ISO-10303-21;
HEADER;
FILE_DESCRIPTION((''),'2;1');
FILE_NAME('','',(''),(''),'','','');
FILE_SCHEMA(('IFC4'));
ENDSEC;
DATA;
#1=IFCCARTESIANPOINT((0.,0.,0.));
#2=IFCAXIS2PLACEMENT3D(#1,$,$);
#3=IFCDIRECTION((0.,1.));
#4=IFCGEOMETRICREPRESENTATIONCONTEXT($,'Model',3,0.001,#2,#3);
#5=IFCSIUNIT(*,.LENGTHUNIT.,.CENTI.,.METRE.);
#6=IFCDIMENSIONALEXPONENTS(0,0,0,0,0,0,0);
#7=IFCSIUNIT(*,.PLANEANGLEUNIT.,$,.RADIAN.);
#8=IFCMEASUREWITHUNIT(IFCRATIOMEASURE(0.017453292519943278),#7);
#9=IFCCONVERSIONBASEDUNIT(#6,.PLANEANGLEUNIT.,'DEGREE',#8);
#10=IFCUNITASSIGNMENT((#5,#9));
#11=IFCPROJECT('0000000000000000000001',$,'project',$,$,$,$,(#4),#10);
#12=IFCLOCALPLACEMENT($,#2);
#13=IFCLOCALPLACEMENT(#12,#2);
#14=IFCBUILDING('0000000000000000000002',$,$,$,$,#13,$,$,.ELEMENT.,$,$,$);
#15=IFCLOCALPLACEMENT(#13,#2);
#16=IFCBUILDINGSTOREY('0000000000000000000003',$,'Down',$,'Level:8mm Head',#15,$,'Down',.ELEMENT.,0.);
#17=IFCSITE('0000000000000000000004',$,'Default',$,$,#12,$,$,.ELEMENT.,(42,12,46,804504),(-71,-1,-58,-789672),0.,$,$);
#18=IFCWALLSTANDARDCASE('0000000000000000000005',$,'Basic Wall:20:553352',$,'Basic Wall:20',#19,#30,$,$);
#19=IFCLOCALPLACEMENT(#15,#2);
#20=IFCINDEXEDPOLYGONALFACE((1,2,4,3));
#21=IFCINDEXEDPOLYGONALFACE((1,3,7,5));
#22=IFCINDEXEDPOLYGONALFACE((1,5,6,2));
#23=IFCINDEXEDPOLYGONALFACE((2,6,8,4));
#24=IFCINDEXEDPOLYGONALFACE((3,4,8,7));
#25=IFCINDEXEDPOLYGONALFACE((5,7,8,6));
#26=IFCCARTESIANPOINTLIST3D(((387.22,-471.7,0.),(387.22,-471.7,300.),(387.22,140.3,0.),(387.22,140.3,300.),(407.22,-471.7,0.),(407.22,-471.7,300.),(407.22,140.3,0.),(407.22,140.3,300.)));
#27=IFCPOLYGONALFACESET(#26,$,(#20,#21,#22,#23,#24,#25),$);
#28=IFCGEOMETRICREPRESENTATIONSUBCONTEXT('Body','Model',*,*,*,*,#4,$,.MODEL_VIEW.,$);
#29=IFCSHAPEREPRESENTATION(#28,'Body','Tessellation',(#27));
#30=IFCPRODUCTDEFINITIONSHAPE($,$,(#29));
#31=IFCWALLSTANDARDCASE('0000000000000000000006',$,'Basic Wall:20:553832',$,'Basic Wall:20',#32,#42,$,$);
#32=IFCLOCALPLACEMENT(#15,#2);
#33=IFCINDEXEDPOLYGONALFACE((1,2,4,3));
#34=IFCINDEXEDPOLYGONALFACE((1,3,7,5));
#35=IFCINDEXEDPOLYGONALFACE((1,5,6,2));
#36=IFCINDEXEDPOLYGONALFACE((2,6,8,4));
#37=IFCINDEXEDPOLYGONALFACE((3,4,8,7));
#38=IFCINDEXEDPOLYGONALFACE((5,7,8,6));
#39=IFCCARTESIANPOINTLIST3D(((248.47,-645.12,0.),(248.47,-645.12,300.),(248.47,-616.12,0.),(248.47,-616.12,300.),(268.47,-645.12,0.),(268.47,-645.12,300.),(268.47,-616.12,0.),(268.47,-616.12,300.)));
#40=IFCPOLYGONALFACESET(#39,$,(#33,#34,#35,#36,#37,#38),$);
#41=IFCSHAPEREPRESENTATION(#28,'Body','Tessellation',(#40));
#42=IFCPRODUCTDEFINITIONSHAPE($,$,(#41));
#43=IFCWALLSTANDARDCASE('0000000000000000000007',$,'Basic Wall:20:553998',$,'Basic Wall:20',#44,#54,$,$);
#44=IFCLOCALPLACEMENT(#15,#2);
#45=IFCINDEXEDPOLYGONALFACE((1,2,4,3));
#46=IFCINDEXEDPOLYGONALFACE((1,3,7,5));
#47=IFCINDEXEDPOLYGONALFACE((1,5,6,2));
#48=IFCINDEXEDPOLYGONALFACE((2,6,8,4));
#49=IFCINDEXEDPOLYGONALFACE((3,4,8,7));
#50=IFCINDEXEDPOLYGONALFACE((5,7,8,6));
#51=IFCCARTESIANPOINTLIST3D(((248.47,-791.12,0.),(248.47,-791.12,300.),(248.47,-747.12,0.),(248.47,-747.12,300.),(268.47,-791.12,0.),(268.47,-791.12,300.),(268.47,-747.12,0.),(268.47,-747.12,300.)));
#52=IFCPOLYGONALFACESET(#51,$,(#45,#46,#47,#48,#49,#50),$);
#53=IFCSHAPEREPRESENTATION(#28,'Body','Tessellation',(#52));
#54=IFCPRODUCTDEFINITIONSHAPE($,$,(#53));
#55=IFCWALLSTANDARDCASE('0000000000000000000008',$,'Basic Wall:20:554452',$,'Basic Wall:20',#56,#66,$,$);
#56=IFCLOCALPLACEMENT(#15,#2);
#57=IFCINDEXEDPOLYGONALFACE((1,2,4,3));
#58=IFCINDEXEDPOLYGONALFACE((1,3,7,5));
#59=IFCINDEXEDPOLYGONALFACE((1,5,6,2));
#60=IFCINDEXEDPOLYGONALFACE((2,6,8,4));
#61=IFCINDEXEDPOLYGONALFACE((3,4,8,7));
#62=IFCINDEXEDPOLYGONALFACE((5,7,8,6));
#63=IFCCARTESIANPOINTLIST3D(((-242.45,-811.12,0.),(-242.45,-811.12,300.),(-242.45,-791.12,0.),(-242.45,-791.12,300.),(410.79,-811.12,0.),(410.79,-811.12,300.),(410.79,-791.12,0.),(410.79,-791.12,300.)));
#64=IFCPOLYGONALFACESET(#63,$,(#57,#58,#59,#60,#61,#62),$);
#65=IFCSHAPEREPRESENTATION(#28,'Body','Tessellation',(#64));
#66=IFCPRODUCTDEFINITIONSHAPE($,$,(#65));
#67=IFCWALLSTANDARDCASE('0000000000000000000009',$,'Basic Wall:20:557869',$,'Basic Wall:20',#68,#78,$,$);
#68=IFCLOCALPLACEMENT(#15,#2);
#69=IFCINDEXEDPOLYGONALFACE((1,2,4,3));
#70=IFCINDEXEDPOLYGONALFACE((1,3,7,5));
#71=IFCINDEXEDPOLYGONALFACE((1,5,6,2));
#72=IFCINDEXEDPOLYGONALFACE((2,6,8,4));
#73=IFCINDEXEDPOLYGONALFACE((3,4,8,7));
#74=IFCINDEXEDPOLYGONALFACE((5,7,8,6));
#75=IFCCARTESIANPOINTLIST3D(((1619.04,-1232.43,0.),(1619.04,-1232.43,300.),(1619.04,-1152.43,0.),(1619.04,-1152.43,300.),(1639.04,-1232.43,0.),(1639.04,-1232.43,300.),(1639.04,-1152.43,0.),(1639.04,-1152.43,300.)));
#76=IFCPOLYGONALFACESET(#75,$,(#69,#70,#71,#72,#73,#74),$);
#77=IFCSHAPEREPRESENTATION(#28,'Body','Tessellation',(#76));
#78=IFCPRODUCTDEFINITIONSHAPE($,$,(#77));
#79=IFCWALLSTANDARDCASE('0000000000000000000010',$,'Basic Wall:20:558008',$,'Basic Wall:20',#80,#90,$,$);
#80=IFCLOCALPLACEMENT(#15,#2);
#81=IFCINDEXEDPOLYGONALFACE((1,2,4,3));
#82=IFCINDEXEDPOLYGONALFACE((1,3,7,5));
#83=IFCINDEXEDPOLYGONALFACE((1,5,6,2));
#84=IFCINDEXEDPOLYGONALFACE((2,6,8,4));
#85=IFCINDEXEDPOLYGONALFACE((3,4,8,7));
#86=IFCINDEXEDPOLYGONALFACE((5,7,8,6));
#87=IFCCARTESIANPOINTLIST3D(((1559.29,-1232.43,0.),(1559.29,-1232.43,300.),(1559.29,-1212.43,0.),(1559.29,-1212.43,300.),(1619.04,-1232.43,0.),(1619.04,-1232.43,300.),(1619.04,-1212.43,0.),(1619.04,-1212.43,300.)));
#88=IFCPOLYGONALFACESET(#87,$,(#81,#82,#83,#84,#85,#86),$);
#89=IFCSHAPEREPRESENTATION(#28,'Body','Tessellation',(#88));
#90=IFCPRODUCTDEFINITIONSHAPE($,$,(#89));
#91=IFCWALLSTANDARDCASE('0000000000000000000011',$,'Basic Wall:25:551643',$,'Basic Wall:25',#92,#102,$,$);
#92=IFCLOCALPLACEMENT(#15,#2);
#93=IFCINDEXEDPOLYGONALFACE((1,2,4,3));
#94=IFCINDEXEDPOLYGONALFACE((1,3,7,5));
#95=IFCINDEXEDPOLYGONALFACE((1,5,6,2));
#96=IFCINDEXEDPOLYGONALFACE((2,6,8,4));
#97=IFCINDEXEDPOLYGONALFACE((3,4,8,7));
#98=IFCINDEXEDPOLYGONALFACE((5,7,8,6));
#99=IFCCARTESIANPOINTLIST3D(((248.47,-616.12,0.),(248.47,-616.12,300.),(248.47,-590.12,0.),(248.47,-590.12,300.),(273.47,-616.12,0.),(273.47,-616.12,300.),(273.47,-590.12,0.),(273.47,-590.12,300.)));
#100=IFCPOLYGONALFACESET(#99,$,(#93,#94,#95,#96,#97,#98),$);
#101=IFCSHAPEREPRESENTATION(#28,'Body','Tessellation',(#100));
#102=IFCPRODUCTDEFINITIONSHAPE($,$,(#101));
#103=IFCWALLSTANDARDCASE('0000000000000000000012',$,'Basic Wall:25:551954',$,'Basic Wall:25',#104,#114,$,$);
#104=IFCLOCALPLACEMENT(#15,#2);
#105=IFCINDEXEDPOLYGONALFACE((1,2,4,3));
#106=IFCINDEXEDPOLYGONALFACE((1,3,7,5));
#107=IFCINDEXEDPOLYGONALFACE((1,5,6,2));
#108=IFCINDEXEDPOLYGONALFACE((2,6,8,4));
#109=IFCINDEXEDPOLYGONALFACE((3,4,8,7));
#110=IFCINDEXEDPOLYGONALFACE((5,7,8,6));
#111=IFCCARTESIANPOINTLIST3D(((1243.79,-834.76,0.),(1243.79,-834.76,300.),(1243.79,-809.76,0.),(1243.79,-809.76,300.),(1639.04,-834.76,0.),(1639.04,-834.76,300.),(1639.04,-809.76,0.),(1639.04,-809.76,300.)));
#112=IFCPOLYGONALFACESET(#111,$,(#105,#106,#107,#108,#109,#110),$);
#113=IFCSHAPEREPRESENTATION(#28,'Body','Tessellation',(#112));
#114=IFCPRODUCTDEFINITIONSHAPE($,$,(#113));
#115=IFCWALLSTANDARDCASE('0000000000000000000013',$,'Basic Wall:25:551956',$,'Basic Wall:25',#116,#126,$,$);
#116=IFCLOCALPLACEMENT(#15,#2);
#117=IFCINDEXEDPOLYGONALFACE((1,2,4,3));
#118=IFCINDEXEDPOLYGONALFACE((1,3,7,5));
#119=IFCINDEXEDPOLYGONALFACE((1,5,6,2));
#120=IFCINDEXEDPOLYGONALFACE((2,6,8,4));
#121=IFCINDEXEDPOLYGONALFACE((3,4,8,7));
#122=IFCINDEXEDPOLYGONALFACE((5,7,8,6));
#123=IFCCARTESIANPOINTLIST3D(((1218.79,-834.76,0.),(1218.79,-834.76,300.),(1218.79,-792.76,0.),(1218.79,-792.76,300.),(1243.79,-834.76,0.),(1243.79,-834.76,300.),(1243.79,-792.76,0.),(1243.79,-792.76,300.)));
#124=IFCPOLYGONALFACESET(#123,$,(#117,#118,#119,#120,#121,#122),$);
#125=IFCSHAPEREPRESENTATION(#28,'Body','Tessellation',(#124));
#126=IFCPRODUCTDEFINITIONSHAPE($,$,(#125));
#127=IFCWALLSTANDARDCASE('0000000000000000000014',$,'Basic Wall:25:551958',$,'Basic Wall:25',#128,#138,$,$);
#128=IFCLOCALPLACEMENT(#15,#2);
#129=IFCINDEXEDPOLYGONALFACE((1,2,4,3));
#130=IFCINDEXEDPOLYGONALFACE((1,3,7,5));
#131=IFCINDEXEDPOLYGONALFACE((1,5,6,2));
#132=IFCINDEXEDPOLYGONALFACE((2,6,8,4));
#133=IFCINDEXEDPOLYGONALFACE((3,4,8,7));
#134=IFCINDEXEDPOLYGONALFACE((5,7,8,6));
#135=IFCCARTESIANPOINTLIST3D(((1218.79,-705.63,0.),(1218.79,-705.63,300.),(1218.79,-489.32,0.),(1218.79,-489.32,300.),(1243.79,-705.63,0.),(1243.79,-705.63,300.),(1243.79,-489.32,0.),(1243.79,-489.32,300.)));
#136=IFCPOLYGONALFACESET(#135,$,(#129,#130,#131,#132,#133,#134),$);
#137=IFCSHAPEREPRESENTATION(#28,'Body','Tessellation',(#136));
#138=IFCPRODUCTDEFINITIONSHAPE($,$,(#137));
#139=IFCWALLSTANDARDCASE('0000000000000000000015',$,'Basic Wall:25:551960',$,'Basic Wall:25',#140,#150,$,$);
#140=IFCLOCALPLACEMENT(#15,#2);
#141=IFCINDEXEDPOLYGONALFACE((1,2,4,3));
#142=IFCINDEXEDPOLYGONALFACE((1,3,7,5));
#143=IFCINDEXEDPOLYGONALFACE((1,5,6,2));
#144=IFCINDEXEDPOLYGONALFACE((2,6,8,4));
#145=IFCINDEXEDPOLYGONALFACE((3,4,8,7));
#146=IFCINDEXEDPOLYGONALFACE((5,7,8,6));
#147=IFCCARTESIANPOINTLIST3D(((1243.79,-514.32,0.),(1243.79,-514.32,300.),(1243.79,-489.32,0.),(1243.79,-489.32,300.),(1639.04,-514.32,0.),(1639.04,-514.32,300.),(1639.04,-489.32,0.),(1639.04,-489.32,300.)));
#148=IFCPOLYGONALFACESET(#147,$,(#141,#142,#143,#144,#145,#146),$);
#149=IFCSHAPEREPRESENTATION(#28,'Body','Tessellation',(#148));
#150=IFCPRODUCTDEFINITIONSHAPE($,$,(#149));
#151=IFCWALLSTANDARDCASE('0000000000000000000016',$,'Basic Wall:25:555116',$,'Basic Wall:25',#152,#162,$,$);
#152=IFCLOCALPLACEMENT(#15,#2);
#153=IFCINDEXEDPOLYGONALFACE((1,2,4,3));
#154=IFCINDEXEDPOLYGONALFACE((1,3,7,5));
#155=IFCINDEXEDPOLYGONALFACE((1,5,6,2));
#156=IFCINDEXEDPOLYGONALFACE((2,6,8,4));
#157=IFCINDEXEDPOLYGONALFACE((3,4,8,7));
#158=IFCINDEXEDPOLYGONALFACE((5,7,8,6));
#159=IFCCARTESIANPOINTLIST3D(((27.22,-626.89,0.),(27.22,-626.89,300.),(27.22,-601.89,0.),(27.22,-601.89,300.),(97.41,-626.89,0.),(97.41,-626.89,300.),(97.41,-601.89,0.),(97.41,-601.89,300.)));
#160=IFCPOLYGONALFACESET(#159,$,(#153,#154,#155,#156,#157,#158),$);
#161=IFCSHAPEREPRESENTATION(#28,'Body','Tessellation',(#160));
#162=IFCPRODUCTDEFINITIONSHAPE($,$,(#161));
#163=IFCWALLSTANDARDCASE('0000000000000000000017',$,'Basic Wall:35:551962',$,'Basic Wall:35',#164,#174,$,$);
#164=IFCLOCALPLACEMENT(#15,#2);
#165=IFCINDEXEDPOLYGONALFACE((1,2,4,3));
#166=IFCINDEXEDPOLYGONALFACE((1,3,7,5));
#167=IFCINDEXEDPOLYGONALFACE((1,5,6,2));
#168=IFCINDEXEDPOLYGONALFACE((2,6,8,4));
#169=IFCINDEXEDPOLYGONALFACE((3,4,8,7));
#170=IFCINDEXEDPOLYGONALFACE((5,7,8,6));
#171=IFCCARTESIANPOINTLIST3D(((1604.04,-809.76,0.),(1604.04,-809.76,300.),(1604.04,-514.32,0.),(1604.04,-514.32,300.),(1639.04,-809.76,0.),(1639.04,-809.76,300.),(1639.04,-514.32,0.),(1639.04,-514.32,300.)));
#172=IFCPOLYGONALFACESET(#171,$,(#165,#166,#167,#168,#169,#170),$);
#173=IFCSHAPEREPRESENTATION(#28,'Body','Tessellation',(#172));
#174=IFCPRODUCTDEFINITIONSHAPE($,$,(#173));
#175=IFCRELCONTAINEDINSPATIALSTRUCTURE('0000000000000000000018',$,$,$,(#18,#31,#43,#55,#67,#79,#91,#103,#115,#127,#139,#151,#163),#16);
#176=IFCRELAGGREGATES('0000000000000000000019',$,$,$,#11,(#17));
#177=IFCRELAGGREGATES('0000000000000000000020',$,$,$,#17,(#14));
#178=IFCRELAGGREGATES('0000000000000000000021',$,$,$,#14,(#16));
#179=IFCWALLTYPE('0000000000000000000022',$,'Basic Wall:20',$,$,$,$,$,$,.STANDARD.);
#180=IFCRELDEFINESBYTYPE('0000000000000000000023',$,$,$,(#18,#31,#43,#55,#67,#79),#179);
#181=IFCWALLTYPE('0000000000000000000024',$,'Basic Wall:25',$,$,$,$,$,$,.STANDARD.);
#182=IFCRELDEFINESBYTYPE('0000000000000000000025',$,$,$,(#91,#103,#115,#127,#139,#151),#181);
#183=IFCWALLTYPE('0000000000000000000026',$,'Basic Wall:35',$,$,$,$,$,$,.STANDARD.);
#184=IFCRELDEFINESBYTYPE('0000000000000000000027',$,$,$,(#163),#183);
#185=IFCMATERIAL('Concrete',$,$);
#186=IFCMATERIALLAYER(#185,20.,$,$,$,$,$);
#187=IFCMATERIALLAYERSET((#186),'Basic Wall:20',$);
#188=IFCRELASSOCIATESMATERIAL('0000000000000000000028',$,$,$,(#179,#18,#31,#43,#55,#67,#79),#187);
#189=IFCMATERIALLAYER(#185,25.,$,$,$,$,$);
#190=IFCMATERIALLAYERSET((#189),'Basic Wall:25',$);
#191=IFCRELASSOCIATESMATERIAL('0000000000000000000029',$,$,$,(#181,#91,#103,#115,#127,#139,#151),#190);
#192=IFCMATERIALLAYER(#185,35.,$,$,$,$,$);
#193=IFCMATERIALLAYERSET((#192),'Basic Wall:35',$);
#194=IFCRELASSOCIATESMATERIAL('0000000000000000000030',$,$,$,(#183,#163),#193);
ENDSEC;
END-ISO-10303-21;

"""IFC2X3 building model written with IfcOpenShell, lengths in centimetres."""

from ifc_helpers import new_model, entity, si_unit, converted_unit, direction, frame, frame_2d, origin, place, context, subcontext, project, spatial, rectangle, extrude, material, layer, layer_set, layer_usage, type_object, element, save


model = new_model("IFC2X3")

# Units and contexts
model_context = context("Model", 3, precision=0.001, world=origin(), true_north=direction((0.0, 1.0)))
body_context = subcontext(model_context, "Body", "Model", "MODEL_VIEW")
ifc_project = project(units=[si_unit("LENGTHUNIT", "METRE", prefix="CENTI"), converted_unit("PLANEANGLEUNIT", "DEGREE", entity("IfcRatioMeasure", 0.017453292519943278), si_unit("PLANEANGLEUNIT", "RADIAN"), dimensions=[0, 0, 0, 0, 0, 0, 0])], contexts=[model_context])

# Site, building, storey
site_placement = place(None, origin())
site = spatial("IfcSite", under=ifc_project, at=site_placement, Name="Default", CompositionType="ELEMENT", RefLatitude=(42, 12, 46, 804504), RefLongitude=(-71, -1, -58, -789672), RefElevation=0.0)
building_placement = place(site_placement, origin())
building = spatial("IfcBuilding", under=site, at=building_placement, CompositionType="ELEMENT")
storey_placement = place(building_placement, origin())
storey = spatial("IfcBuildingStorey", under=building, at=storey_placement, Name="Down", ObjectType="Level:8mm Head", LongName="Down", CompositionType="ELEMENT", Elevation=0.0)

# Shared definitions
ifc_material = material(Name="Concrete")

# Walls
ifc_layer_1 = layer(ifc_material, 20.0)
ifc_layer_set_1 = layer_set([ifc_layer_1], Name="Basic Wall:20")
wall_type_1 = type_object("IfcWallType", Name="Basic Wall:20", PredefinedType="STANDARD", material=ifc_layer_set_1)
ifc_layer_usage_1 = layer_usage(ifc_layer_set_1, "AXIS2", "NEGATIVE", 10.0)
wall_1_placement = place(storey_placement, frame((397.22, -471.7, 0.0), z_axis=(0.0, 0.0, 1.0), x_axis=(0.0, 1.0, 0.0)))
element("IfcWallStandardCase", 1, at=wall_1_placement, inside=storey, type_object=wall_type_1, material=ifc_layer_usage_1, Name="Basic Wall:20:553352", ObjectType="Basic Wall:20", context=body_context, shape_type="SweptSolid", body=[
    extrude(rectangle(XDim=612.0, YDim=20.0, at=frame_2d((306.0, 0.0), x_axis=(-1.0, 0.0))), origin(), (0.0, 0.0, 1.0), 300.0),
])
ifc_layer_usage_2 = layer_usage(ifc_layer_set_1, "AXIS2", "POSITIVE", -10.0)
wall_2_placement = place(storey_placement, frame((258.47, -616.12, 0.0), z_axis=(0.0, 0.0, 1.0), x_axis=(0.0, -1.0, 0.0)))
element("IfcWallStandardCase", 2, at=wall_2_placement, inside=storey, type_object=wall_type_1, material=ifc_layer_usage_2, Name="Basic Wall:20:553832", ObjectType="Basic Wall:20", context=body_context, shape_type="SweptSolid", body=[
    extrude(rectangle(XDim=29.0, YDim=20.0, at=frame_2d((14.5, 0.0), x_axis=(-1.0, 0.0))), origin(), (0.0, 0.0, 1.0), 300.0),
])
ifc_layer_usage_3 = layer_usage(ifc_layer_set_1, "AXIS2", "POSITIVE", -10.0)
wall_3_placement = place(storey_placement, frame((258.47, -747.12, 0.0), z_axis=(0.0, 0.0, 1.0), x_axis=(0.0, -1.0, 0.0)))
element("IfcWallStandardCase", 3, at=wall_3_placement, inside=storey, type_object=wall_type_1, material=ifc_layer_usage_3, Name="Basic Wall:20:553998", ObjectType="Basic Wall:20", context=body_context, shape_type="SweptSolid", body=[
    extrude(rectangle(XDim=44.0, YDim=20.0, at=frame_2d((22.0, 0.0), x_axis=(-1.0, 0.0))), origin(), (0.0, 0.0, 1.0), 300.0),
])
ifc_layer_usage_4 = layer_usage(ifc_layer_set_1, "AXIS2", "NEGATIVE", 10.0)
wall_4_placement = place(storey_placement, frame((410.79, -801.12, 0.0), z_axis=(0.0, 0.0, 1.0), x_axis=(-1.0, 0.0, 0.0)))
element("IfcWallStandardCase", 4, at=wall_4_placement, inside=storey, type_object=wall_type_1, material=ifc_layer_usage_4, Name="Basic Wall:20:554452", ObjectType="Basic Wall:20", context=body_context, shape_type="SweptSolid", body=[
    extrude(rectangle(XDim=653.23, YDim=20.0, at=frame_2d((326.62, 0.0), x_axis=(-1.0, 0.0))), origin(), (0.0, 0.0, 1.0), 300.0),
])
ifc_layer_usage_5 = layer_usage(ifc_layer_set_1, "AXIS2", "NEGATIVE", 10.0)
wall_5_placement = place(storey_placement, frame((1629.04, -1152.43, 0.0), z_axis=(0.0, 0.0, 1.0), x_axis=(0.0, -1.0, 0.0)))
element("IfcWallStandardCase", 5, at=wall_5_placement, inside=storey, type_object=wall_type_1, material=ifc_layer_usage_5, Name="Basic Wall:20:557869", ObjectType="Basic Wall:20", context=body_context, shape_type="SweptSolid", body=[
    extrude(rectangle(XDim=80.0, YDim=20.0, at=frame_2d((40.0, 0.0), x_axis=(-1.0, 0.0))), origin(), (0.0, 0.0, 1.0), 300.0),
])
ifc_layer_usage_6 = layer_usage(ifc_layer_set_1, "AXIS2", "NEGATIVE", 10.0)
wall_6_placement = place(storey_placement, frame((1619.04, -1222.43, 0.0), z_axis=(0.0, 0.0, 1.0), x_axis=(-1.0, 0.0, 0.0)))
element("IfcWallStandardCase", 6, at=wall_6_placement, inside=storey, type_object=wall_type_1, material=ifc_layer_usage_6, Name="Basic Wall:20:558008", ObjectType="Basic Wall:20", context=body_context, shape_type="SweptSolid", body=[
    extrude(rectangle(XDim=59.75, YDim=20.0, at=frame_2d((29.88, 0.0), x_axis=(-1.0, 0.0))), origin(), (0.0, 0.0, 1.0), 300.0),
])
ifc_layer_2 = layer(ifc_material, 25.0)
ifc_layer_set_2 = layer_set([ifc_layer_2], Name="Basic Wall:25")
ifc_layer_usage_7 = layer_usage(ifc_layer_set_2, "AXIS2", "NEGATIVE", 12.5)
wall_type_2 = type_object("IfcWallType", Name="Basic Wall:25", PredefinedType="STANDARD", material=ifc_layer_set_2)
wall_7_placement = place(storey_placement, frame((260.97, -590.12, 0.0), z_axis=(0.0, 0.0, 1.0), x_axis=(0.0, -1.0, 0.0)))
element("IfcWallStandardCase", 7, at=wall_7_placement, inside=storey, type_object=wall_type_2, material=ifc_layer_usage_7, Name="Basic Wall:25:551643", ObjectType="Basic Wall:25", context=body_context, shape_type="SweptSolid", body=[
    extrude(rectangle(XDim=26.0, YDim=25.0, at=frame_2d((13.0, 0.0), x_axis=(-1.0, 0.0))), origin(), (0.0, 0.0, 1.0), 300.0),
])
ifc_layer_usage_8 = layer_usage(ifc_layer_set_2, "AXIS2", "POSITIVE", -12.5)
wall_8_placement = place(storey_placement, frame((1243.79, -822.26, 0.0)))
element("IfcWallStandardCase", 8, at=wall_8_placement, inside=storey, type_object=wall_type_2, material=ifc_layer_usage_8, Name="Basic Wall:25:551954", ObjectType="Basic Wall:25", context=body_context, shape_type="SweptSolid", body=[
    extrude(rectangle(XDim=395.26, YDim=25.0, at=frame_2d((197.63, 0.0), x_axis=(-1.0, 0.0))), origin(), (0.0, 0.0, 1.0), 300.0),
])
ifc_layer_usage_9 = layer_usage(ifc_layer_set_2, "AXIS2", "NEGATIVE", 12.5)
wall_9_placement = place(storey_placement, frame((1231.29, -834.76, 0.0), z_axis=(0.0, 0.0, 1.0), x_axis=(0.0, 1.0, 0.0)))
element("IfcWallStandardCase", 9, at=wall_9_placement, inside=storey, type_object=wall_type_2, material=ifc_layer_usage_9, Name="Basic Wall:25:551956", ObjectType="Basic Wall:25", context=body_context, shape_type="SweptSolid", body=[
    extrude(rectangle(XDim=42.0, YDim=25.0, at=frame_2d((21.0, 0.0), x_axis=(-1.0, 0.0))), origin(), (0.0, 0.0, 1.0), 300.0),
])
ifc_layer_usage_10 = layer_usage(ifc_layer_set_2, "AXIS2", "NEGATIVE", 12.5)
wall_10_placement = place(storey_placement, frame((1231.29, -705.63, 0.0), z_axis=(0.0, 0.0, 1.0), x_axis=(0.0, 1.0, 0.0)))
element("IfcWallStandardCase", 10, at=wall_10_placement, inside=storey, type_object=wall_type_2, material=ifc_layer_usage_10, Name="Basic Wall:25:551958", ObjectType="Basic Wall:25", context=body_context, shape_type="SweptSolid", body=[
    extrude(rectangle(XDim=216.31, YDim=25.0, at=frame_2d((108.15, 0.0), x_axis=(-1.0, 0.0))), origin(), (0.0, 0.0, 1.0), 300.0),
])
ifc_layer_usage_11 = layer_usage(ifc_layer_set_2, "AXIS2", "NEGATIVE", 12.5)
wall_11_placement = place(storey_placement, frame((1243.79, -501.82, 0.0)))
element("IfcWallStandardCase", 11, at=wall_11_placement, inside=storey, type_object=wall_type_2, material=ifc_layer_usage_11, Name="Basic Wall:25:551960", ObjectType="Basic Wall:25", context=body_context, shape_type="SweptSolid", body=[
    extrude(rectangle(XDim=395.26, YDim=25.0, at=frame_2d((197.63, 0.0), x_axis=(-1.0, 0.0))), origin(), (0.0, 0.0, 1.0), 300.0),
])
ifc_layer_usage_12 = layer_usage(ifc_layer_set_2, "AXIS2", "POSITIVE", -12.5)
wall_12_placement = place(storey_placement, frame((97.41, -614.39, 0.0), z_axis=(0.0, 0.0, 1.0), x_axis=(-1.0, 0.0, 0.0)))
element("IfcWallStandardCase", 12, at=wall_12_placement, inside=storey, type_object=wall_type_2, material=ifc_layer_usage_12, Name="Basic Wall:25:555116", ObjectType="Basic Wall:25", context=body_context, shape_type="SweptSolid", body=[
    extrude(rectangle(XDim=70.19, YDim=25.0, at=frame_2d((35.09, 0.0), x_axis=(-1.0, 0.0))), origin(), (0.0, 0.0, 1.0), 300.0),
])
ifc_layer_3 = layer(ifc_material, 35.0)
ifc_layer_set_3 = layer_set([ifc_layer_3], Name="Basic Wall:35")
ifc_layer_usage_13 = layer_usage(ifc_layer_set_3, "AXIS2", "POSITIVE", -17.5)
wall_type_3 = type_object("IfcWallType", Name="Basic Wall:35", PredefinedType="STANDARD", material=ifc_layer_set_3)
wall_13_placement = place(storey_placement, frame((1621.54, -514.32, 0.0), z_axis=(0.0, 0.0, 1.0), x_axis=(0.0, -1.0, 0.0)))
element("IfcWallStandardCase", 13, at=wall_13_placement, inside=storey, type_object=wall_type_3, material=ifc_layer_usage_13, Name="Basic Wall:35:551962", ObjectType="Basic Wall:35", context=body_context, shape_type="SweptSolid", body=[
    extrude(rectangle(XDim=295.44, YDim=35.0, at=frame_2d((147.72, 0.0), x_axis=(-1.0, 0.0))), origin(), (0.0, 0.0, 1.0), 300.0),
])

save(model, "model.ifc")
